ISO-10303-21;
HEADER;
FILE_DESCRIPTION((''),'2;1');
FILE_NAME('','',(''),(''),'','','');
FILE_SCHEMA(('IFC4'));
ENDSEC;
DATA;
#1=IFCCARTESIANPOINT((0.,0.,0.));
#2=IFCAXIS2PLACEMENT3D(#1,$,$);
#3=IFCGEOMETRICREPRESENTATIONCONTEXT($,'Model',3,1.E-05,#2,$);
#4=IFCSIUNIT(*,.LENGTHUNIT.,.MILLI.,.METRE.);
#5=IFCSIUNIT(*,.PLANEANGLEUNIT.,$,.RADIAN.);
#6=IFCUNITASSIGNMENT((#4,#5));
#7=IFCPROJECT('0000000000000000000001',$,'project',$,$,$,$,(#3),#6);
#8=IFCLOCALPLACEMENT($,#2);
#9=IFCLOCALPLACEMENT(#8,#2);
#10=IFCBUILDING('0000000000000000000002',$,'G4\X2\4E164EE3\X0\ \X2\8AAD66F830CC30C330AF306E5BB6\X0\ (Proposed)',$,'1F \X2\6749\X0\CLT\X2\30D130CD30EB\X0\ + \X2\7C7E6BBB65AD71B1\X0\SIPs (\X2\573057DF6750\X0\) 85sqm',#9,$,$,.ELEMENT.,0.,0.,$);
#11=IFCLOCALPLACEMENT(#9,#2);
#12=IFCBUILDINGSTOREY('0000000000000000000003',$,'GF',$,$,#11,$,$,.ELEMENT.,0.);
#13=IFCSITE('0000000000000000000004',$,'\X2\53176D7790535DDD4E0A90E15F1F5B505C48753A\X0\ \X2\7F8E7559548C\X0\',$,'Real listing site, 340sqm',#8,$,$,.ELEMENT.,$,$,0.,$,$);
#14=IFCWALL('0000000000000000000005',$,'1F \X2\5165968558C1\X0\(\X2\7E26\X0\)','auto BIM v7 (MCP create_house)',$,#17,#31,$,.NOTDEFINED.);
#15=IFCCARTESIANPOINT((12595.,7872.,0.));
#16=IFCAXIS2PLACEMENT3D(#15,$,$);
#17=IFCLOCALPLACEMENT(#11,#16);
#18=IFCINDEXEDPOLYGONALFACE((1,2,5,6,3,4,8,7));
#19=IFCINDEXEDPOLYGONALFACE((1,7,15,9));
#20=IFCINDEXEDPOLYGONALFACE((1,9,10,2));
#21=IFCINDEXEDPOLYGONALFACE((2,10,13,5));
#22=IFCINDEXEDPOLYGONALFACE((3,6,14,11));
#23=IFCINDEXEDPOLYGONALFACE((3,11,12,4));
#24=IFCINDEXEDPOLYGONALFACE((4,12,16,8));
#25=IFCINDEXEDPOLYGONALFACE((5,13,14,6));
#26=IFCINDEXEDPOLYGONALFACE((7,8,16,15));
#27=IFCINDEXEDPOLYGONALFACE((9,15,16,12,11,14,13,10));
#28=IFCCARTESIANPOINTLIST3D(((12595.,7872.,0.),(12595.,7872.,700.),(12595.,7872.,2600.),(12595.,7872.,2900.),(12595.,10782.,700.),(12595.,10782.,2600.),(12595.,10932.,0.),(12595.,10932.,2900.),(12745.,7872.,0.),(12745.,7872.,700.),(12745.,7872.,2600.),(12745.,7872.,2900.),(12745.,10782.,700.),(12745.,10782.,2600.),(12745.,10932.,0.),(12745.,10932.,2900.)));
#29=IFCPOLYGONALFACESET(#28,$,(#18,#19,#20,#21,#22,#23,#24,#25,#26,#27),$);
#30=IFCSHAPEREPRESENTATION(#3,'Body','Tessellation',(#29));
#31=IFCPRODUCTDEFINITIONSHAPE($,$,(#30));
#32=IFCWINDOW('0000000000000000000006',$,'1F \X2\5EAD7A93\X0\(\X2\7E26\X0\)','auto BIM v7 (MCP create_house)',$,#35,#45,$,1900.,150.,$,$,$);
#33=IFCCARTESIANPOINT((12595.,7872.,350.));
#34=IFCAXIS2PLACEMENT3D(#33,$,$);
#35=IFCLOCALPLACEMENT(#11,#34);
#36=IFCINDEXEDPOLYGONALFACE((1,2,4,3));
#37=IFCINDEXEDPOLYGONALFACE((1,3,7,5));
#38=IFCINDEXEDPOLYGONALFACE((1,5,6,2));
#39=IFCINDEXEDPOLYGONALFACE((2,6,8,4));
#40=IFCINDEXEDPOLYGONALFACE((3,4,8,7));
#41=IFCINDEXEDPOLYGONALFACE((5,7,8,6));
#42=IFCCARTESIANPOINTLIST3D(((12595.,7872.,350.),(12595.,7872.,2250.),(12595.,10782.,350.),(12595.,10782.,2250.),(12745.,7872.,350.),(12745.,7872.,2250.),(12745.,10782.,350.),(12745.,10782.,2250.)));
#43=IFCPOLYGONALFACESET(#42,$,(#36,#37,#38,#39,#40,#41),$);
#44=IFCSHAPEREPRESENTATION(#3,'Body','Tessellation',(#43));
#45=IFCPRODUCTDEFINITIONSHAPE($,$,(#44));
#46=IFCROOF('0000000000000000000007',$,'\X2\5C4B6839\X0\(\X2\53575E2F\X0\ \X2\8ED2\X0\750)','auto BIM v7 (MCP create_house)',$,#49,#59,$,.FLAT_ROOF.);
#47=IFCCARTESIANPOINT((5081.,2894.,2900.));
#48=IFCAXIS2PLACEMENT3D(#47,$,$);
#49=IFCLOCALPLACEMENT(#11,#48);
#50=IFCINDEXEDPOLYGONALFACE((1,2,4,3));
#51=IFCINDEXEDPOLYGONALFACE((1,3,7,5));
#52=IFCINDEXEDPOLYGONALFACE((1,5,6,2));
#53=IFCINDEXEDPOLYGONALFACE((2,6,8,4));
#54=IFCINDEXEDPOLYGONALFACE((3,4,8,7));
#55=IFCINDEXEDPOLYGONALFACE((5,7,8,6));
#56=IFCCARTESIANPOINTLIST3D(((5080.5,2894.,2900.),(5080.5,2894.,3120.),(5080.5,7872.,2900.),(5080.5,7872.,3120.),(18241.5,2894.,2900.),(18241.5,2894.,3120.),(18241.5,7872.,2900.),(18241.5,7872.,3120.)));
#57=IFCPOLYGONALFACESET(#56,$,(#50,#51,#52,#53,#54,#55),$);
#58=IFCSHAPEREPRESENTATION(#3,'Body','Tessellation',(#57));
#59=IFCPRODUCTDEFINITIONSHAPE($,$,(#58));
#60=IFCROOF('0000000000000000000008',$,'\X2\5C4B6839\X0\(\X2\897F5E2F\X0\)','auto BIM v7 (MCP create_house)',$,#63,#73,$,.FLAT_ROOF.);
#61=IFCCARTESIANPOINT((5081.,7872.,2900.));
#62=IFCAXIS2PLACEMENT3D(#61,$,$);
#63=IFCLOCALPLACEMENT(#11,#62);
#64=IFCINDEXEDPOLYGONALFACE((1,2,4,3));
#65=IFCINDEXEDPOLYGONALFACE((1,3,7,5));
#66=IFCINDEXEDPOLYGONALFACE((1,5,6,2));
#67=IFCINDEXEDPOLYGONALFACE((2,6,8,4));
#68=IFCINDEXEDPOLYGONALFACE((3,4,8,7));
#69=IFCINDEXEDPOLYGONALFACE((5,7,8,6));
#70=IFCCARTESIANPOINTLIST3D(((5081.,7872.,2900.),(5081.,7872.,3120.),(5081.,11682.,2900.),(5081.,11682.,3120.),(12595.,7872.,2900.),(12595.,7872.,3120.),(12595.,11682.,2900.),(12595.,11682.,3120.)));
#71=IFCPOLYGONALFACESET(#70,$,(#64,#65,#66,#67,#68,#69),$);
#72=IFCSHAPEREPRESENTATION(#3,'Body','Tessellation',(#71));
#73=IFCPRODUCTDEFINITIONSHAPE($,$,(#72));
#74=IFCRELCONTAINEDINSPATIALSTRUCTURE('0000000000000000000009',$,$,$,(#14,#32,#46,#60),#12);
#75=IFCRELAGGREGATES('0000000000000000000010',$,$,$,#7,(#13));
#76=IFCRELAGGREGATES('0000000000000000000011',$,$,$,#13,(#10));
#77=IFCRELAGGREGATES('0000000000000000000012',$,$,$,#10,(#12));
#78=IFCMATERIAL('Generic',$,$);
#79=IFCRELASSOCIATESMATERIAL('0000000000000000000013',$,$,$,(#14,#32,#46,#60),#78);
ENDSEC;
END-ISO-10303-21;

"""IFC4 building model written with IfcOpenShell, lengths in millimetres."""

from ifc_helpers import new_model, si_unit, frame, frame_2d, origin, place, context, project, spatial, rectangle, extrude, material, element, fill, save


model = new_model("IFC4")

# Units and contexts
model_context = context("Model", 3, precision=1e-05, world=origin())
ifc_project = project(units=[si_unit("LENGTHUNIT", "METRE", prefix="MILLI"), si_unit("PLANEANGLEUNIT", "RADIAN")], contexts=[model_context])

# Site, building, storey
site_placement = place(None, origin())
site = spatial("IfcSite", under=ifc_project, at=site_placement, Name="北海道川上郡弟子屈町 美留和", ObjectType="Real listing site, 340sqm", CompositionType="ELEMENT", RefElevation=0.0)
building_placement = place(site_placement, origin())
building = spatial("IfcBuilding", under=site, at=building_placement, Name="G4世代 読書ヌックの家 (Proposed)", ObjectType="1F 杉CLTパネル + 籾殻断熱SIPs (地域材) 85sqm", CompositionType="ELEMENT", ElevationOfRefHeight=0.0, ElevationOfTerrain=0.0)
storey_placement = place(building_placement, origin())
storey = spatial("IfcBuildingStorey", under=building, at=storey_placement, Name="GF", CompositionType="ELEMENT", Elevation=0.0)

# Shared definitions
ifc_material = material(Name="Generic")

# Wall, opening, window
wall_1_placement = place(storey_placement, frame((12595.0, 7872.0, 0.0)))
wall_1 = element("IfcWall", 1, at=wall_1_placement, inside=storey, material=ifc_material, Name="1F 入隅壁(縦)", Description="auto BIM v7 (MCP create_house)", PredefinedType="NOTDEFINED", context=model_context, shape_type="SweptSolid", body=[
    extrude(rectangle(XDim=150.0, YDim=3060.0, at=frame_2d((75.0, 1530.0))), frame((12595.0, 7872.0, 0.0)), (0.0, 0.0, 1.0), 2900.0),
])
opening_1_placement = place(storey_placement, frame((12595.0, 7872.0, 350.0)))
opening_1 = element("IfcOpeningElement", 2, at=opening_1_placement, cuts=wall_1, PredefinedType="NOTDEFINED", context=model_context, shape_type="SweptSolid", body=[
    extrude(rectangle(XDim=150.0, YDim=2910.0, at=frame_2d((75.0, 1455.0))), frame((12595.0, 7872.0, 350.0)), (0.0, 0.0, 1.0), 1900.0),
])
window_1_placement = place(storey_placement, frame((12595.0, 7872.0, 350.0)))
window_1 = element("IfcWindow", 3, at=window_1_placement, inside=storey, material=ifc_material, Name="1F 庭窓(縦)", Description="auto BIM v7 (MCP create_house)", OverallHeight=1900.0, OverallWidth=150.0, context=model_context, shape_type="SweptSolid", body=[
    extrude(rectangle(XDim=150.0, YDim=2910.0, at=frame_2d((75.0, 1455.0))), frame((12595.0, 7872.0, 350.0)), (0.0, 0.0, 1.0), 1900.0),
])
fill(opening_1, window_1)

# Roofs
roof_1_placement = place(storey_placement, frame((5081.0, 2894.0, 2900.0)))
element("IfcRoof", 4, at=roof_1_placement, inside=storey, material=ifc_material, Name="屋根(南帯 軒750)", Description="auto BIM v7 (MCP create_house)", PredefinedType="FLAT_ROOF", context=model_context, shape_type="SweptSolid", body=[
    extrude(rectangle(XDim=13161.0, YDim=4978.0, at=frame_2d((6580.0, 2489.0))), frame((5081.0, 2894.0, 2900.0)), (0.0, 0.0, 1.0), 220.0),
])
roof_2_placement = place(storey_placement, frame((5081.0, 7872.0, 2900.0)))
element("IfcRoof", 5, at=roof_2_placement, inside=storey, material=ifc_material, Name="屋根(西帯)", Description="auto BIM v7 (MCP create_house)", PredefinedType="FLAT_ROOF", context=model_context, shape_type="SweptSolid", body=[
    extrude(rectangle(XDim=7514.0, YDim=3810.0, at=frame_2d((3757.0, 1905.0))), frame((5081.0, 7872.0, 2900.0)), (0.0, 0.0, 1.0), 220.0),
])

save(model, "model.ifc")
